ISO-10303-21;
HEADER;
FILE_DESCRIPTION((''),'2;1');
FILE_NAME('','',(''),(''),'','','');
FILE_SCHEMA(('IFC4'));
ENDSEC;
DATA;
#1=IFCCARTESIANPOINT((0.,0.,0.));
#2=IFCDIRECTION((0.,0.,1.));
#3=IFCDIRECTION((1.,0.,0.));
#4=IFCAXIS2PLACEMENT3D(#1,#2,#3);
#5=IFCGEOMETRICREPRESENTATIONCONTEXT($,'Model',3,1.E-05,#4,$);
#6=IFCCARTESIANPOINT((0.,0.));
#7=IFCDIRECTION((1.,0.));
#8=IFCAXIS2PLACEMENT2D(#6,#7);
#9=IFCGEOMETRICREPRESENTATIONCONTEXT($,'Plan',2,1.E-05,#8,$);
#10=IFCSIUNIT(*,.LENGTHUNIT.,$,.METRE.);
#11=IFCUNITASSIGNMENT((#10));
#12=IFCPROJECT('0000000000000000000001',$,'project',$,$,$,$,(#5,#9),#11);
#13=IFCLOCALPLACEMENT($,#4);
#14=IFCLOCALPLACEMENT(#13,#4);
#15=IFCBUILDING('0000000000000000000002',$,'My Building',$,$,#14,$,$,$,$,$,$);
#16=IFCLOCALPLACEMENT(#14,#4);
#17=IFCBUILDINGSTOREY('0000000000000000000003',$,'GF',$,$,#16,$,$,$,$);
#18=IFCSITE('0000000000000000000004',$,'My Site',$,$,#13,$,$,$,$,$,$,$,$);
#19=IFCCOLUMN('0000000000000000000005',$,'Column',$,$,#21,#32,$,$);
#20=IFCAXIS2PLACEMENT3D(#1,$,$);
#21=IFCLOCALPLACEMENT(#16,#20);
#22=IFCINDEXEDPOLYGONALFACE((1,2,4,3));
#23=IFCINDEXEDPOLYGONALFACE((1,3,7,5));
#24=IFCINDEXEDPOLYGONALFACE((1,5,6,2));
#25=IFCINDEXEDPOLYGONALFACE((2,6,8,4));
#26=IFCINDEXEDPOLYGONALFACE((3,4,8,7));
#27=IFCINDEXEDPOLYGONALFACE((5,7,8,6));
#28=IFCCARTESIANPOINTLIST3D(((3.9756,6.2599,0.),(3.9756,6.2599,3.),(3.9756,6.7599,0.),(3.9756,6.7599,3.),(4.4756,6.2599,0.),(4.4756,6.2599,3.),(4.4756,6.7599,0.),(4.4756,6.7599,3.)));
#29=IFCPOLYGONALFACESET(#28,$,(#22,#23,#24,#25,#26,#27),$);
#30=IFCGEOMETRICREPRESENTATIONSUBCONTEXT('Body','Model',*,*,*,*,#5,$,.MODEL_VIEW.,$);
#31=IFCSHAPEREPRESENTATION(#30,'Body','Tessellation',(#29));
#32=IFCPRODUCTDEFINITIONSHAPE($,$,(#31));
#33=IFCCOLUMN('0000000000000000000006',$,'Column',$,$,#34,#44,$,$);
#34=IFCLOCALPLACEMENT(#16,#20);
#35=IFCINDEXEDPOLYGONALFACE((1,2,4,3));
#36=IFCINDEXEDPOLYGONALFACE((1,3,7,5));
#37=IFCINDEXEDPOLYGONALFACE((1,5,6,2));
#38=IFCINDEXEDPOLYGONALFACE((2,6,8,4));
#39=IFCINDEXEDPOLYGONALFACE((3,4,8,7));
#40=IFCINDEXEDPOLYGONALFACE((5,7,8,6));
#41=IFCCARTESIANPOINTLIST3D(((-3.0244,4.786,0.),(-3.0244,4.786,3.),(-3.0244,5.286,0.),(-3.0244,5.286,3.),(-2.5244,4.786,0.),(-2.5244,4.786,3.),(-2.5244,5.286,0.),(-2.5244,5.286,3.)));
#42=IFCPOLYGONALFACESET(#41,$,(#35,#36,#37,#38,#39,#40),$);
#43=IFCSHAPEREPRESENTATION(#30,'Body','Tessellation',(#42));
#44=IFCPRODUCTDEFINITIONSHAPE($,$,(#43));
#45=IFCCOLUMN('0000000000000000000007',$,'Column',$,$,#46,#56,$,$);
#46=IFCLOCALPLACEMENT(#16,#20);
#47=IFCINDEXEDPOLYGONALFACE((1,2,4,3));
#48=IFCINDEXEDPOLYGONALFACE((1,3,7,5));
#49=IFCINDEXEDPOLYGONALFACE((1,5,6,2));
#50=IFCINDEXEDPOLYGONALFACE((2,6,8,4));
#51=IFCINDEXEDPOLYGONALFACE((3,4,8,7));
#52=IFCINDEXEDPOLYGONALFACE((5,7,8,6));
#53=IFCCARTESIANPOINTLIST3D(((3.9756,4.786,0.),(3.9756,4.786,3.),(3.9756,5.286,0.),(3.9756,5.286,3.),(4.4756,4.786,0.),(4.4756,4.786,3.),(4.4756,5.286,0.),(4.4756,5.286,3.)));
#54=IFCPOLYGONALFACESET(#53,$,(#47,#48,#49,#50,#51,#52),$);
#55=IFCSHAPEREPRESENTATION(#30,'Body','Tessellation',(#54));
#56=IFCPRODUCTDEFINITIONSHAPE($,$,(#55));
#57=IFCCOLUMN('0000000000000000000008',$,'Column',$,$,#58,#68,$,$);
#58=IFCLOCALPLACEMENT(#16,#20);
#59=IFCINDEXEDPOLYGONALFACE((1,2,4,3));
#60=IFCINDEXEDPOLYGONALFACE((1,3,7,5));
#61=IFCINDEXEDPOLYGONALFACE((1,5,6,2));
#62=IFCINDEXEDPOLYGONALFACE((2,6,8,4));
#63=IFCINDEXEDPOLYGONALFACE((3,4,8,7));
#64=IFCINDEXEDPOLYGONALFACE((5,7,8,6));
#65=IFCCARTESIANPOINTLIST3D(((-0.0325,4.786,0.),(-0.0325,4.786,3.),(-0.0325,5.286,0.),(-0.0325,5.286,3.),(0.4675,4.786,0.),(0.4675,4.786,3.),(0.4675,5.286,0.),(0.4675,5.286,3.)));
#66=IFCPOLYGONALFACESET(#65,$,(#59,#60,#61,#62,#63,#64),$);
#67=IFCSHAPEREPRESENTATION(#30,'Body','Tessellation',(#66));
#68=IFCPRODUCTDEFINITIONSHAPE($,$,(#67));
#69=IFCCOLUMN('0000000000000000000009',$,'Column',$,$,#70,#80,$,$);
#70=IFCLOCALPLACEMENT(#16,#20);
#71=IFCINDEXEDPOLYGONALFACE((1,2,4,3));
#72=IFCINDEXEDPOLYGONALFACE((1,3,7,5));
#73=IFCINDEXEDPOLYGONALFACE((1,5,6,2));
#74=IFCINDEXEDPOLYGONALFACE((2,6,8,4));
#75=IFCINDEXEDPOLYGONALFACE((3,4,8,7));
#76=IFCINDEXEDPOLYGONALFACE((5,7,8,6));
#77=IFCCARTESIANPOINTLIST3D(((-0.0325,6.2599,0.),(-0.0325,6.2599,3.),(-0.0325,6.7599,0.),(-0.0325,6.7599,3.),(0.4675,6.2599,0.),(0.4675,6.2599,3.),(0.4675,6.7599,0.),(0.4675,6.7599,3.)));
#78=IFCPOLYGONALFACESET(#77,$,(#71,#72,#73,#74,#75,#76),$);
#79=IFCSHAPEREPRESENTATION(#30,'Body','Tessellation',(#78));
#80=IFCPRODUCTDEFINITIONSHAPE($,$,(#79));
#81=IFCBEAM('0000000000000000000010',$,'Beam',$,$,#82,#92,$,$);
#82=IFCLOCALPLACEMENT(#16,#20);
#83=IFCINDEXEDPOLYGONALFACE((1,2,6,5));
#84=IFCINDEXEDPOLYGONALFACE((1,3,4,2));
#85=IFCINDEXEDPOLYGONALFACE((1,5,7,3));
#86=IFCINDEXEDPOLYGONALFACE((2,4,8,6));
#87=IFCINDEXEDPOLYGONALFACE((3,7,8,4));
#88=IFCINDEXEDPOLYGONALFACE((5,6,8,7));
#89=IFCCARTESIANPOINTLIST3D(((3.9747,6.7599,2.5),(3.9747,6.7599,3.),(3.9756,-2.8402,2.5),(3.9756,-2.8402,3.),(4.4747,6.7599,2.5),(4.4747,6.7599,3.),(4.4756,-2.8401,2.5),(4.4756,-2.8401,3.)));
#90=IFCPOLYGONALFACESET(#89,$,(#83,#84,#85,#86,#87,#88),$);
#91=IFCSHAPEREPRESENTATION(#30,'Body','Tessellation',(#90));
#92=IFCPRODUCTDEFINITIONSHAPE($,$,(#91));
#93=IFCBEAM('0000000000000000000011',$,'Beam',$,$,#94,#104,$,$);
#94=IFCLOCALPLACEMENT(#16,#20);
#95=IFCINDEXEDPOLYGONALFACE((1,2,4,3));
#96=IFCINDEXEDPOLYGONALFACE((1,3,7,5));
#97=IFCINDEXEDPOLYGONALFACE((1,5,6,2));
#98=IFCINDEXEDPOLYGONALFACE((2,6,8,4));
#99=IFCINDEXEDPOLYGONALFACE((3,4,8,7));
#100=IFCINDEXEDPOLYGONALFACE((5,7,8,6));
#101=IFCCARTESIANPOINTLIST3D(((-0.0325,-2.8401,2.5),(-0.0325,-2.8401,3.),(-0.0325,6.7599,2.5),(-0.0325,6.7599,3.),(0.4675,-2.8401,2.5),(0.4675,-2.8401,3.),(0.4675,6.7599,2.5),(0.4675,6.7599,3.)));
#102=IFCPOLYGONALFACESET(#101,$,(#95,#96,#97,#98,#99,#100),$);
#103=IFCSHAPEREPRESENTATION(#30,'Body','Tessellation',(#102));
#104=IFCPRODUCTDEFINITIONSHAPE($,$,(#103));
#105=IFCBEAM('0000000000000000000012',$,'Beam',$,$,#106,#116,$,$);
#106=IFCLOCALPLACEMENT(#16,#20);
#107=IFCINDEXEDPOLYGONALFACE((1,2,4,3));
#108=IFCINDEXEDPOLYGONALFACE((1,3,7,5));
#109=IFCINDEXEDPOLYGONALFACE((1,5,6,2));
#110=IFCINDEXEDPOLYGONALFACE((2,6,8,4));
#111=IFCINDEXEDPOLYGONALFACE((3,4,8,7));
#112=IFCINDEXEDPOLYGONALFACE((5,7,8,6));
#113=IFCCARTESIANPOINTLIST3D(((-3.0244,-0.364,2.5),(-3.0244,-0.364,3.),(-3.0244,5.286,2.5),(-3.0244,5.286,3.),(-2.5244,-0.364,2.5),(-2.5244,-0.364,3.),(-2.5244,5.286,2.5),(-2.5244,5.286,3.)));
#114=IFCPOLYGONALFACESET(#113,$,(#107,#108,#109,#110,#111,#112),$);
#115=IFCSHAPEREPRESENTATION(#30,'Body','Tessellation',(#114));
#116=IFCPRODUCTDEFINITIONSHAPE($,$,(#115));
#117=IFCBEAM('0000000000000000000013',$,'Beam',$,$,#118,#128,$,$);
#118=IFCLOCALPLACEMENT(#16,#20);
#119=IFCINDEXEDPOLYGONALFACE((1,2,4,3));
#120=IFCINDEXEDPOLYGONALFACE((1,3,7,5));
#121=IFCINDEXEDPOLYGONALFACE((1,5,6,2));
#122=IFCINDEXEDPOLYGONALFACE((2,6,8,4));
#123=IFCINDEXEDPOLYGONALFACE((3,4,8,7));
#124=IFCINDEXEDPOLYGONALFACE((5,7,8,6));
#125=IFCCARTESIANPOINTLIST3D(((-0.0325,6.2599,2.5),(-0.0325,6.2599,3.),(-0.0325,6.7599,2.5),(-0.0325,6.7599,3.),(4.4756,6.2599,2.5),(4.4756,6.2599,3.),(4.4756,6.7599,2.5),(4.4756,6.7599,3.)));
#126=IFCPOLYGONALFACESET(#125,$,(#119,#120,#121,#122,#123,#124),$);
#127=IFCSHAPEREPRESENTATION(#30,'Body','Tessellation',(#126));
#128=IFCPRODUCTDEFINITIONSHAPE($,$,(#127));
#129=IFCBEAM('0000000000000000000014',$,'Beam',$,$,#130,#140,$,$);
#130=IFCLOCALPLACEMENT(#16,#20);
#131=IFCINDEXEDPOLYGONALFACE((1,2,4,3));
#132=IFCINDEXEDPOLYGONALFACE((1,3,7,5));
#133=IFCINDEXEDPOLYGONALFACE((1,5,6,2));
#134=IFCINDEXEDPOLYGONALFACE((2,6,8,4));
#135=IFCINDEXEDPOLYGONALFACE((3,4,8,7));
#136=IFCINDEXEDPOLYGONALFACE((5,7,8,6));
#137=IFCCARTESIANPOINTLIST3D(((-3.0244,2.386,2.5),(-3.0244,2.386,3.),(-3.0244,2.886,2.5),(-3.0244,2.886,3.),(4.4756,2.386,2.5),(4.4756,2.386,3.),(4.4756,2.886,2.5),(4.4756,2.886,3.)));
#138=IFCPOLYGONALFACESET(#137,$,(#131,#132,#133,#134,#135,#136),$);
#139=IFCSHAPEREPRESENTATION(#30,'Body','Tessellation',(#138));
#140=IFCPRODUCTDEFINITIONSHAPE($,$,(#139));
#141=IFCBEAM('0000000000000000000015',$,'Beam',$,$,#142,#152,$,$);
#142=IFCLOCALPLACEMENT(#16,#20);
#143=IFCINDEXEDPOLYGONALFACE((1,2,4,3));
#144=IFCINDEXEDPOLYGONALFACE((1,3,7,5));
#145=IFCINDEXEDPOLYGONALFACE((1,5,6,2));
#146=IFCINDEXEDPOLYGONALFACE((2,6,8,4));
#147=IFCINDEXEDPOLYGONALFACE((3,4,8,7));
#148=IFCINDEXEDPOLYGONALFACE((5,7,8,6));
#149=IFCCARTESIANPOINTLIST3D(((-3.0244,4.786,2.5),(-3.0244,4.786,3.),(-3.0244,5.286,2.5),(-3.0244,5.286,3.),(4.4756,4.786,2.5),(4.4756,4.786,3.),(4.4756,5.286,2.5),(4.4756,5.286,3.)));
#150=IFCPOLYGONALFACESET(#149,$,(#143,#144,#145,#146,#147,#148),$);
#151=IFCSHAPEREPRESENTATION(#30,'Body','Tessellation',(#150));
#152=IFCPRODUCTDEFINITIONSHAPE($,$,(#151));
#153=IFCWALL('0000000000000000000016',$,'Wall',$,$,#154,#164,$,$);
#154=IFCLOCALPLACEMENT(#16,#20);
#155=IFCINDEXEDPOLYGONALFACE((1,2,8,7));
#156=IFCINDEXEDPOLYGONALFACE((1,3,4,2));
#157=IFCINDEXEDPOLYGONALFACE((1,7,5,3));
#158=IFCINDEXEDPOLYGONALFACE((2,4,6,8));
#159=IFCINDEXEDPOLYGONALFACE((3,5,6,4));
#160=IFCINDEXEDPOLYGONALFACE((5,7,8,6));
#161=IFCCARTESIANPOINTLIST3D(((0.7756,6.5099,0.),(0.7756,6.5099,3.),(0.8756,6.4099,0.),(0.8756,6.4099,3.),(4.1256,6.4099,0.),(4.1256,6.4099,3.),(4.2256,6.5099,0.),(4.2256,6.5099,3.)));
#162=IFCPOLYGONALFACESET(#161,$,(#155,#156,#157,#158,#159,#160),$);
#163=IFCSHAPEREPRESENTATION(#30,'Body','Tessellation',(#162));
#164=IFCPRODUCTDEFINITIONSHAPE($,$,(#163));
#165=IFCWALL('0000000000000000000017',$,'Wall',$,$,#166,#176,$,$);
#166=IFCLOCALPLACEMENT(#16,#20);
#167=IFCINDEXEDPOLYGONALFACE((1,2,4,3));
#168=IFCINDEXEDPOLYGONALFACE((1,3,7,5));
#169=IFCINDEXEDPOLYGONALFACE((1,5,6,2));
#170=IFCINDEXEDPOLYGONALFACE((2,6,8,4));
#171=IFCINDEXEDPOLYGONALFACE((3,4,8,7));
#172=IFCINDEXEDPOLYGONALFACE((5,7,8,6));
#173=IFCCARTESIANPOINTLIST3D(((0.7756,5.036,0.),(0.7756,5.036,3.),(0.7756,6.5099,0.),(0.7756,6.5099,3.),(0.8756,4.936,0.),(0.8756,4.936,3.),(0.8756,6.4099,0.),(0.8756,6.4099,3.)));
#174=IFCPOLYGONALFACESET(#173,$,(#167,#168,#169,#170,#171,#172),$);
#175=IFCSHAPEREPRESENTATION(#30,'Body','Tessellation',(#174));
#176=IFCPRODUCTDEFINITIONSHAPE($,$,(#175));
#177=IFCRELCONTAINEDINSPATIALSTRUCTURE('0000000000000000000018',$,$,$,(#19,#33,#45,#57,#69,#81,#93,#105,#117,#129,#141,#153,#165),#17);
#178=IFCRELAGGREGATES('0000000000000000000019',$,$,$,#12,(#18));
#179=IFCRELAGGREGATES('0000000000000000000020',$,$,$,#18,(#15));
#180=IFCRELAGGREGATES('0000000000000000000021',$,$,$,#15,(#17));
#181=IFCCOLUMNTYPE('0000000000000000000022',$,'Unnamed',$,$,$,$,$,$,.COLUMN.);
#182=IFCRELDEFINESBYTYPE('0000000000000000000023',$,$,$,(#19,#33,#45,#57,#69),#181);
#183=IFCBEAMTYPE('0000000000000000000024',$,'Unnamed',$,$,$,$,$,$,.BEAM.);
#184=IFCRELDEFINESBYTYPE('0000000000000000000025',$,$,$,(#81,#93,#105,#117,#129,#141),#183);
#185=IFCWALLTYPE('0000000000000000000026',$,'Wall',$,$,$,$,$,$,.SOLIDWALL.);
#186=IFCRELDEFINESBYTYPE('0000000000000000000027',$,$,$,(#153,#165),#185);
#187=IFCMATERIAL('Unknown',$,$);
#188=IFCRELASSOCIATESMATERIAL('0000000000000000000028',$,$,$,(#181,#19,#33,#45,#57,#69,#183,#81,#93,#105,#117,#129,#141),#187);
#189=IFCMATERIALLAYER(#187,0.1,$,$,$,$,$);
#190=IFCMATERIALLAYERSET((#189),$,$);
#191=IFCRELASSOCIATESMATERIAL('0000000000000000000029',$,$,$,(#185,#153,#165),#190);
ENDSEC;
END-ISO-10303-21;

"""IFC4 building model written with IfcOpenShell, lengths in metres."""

from ifc_helpers import new_model, si_unit, frame, origin_with_axes, origin_2d_with_axis, place, context, subcontext, project, spatial, line, indexed_curve, rectangle, outline, extrude, material, layer, layer_set, layer_usage, material_profile, profile_set, profile_usage, type_object, element, save


model = new_model("IFC4")

# Units and contexts
model_context = context("Model", 3, precision=1e-05, world=origin_with_axes())
plan_context = context("Plan", 2, precision=1e-05, world=origin_2d_with_axis())
body_context_1 = subcontext(model_context, "Body", "Model", "MODEL_VIEW")
ifc_project = project(units=[si_unit("LENGTHUNIT", "METRE")], contexts=[model_context, plan_context])

# Site, building, storey
site_placement = place(None, origin_with_axes())
site = spatial("IfcSite", under=ifc_project, at=site_placement, Name="My Site")
building_placement = place(site_placement, origin_with_axes())
building = spatial("IfcBuilding", under=site, at=building_placement, Name="My Building")
storey_placement = place(building_placement, origin_with_axes())
storey = spatial("IfcBuildingStorey", under=building, at=storey_placement, Name="GF")

# Columns
ifc_material_1 = material(Name="Unknown")
ifc_material_profile_1 = material_profile(ifc_material_1, rectangle(XDim=0.5, YDim=0.5))
ifc_profile_set_1 = profile_set([ifc_material_profile_1])
ifc_profile_usage_1 = profile_usage(ifc_profile_set_1, cardinal=5)
column_type = type_object("IfcColumnType", Name="Unnamed", PredefinedType="COLUMN", material=ifc_profile_set_1)
column_1_placement = place(storey_placement, frame((4.2256, 6.5099, 0.0), z_axis=(0.0, 0.0, 1.0), x_axis=(1.0, 0.0, 0.0)))
element("IfcColumn", 1, at=column_1_placement, inside=storey, type_object=column_type, material=ifc_profile_usage_1, Name="Column", context=body_context_1, shape_type="SweptSolid", body=[
    extrude(rectangle(XDim=0.5, YDim=0.5), origin_with_axes(), (0.0, 0.0, 1.0), 3.0),
])
ifc_profile_usage_2 = profile_usage(ifc_profile_set_1, cardinal=5)
column_2_placement = place(storey_placement, frame((-2.7744, 5.036, 0.0), z_axis=(0.0, 0.0, 1.0), x_axis=(1.0, 0.0, 0.0)))
element("IfcColumn", 2, at=column_2_placement, inside=storey, type_object=column_type, material=ifc_profile_usage_2, Name="Column", context=body_context_1, shape_type="SweptSolid", body=[
    extrude(rectangle(XDim=0.5, YDim=0.5), origin_with_axes(), (0.0, 0.0, 1.0), 3.0),
])
ifc_profile_usage_3 = profile_usage(ifc_profile_set_1, cardinal=5)
column_3_placement = place(storey_placement, frame((4.2256, 5.036, 0.0), z_axis=(0.0, 0.0, 1.0), x_axis=(1.0, 0.0, 0.0)))
element("IfcColumn", 3, at=column_3_placement, inside=storey, type_object=column_type, material=ifc_profile_usage_3, Name="Column", context=body_context_1, shape_type="SweptSolid", body=[
    extrude(rectangle(XDim=0.5, YDim=0.5), origin_with_axes(), (0.0, 0.0, 1.0), 3.0),
])
ifc_profile_usage_4 = profile_usage(ifc_profile_set_1, cardinal=5)
column_4_placement = place(storey_placement, frame((0.2175, 5.036, 0.0), z_axis=(0.0, 0.0, 1.0), x_axis=(1.0, 0.0, 0.0)))
element("IfcColumn", 4, at=column_4_placement, inside=storey, type_object=column_type, material=ifc_profile_usage_4, Name="Column", context=body_context_1, shape_type="SweptSolid", body=[
    extrude(rectangle(XDim=0.5, YDim=0.5), origin_with_axes(), (0.0, 0.0, 1.0), 3.0),
])
ifc_profile_usage_5 = profile_usage(ifc_profile_set_1, cardinal=5)
column_5_placement = place(storey_placement, frame((0.2175, 6.5099, 0.0), z_axis=(0.0, 0.0, 1.0), x_axis=(1.0, 0.0, 0.0)))
element("IfcColumn", 5, at=column_5_placement, inside=storey, type_object=column_type, material=ifc_profile_usage_5, Name="Column", context=body_context_1, shape_type="SweptSolid", body=[
    extrude(rectangle(XDim=0.5, YDim=0.5), origin_with_axes(), (0.0, 0.0, 1.0), 3.0),
])

# Beams
ifc_material_profile_2 = material_profile(ifc_material_1, rectangle(XDim=0.5, YDim=0.5))
ifc_profile_set_2 = profile_set([ifc_material_profile_2])
ifc_profile_usage_6 = profile_usage(ifc_profile_set_2, cardinal=7)
beam_type = type_object("IfcBeamType", Name="Unnamed", PredefinedType="BEAM", material=ifc_profile_set_2)
beam_1_placement = place(storey_placement, frame((4.4747, 6.7599, 3.0), z_axis=(0.000095, -1.0, 0.0), x_axis=(1.0, 0.000095, 0.0)))
element("IfcBeam", 6, at=beam_1_placement, inside=storey, type_object=beam_type, material=ifc_profile_usage_6, Name="Beam", context=body_context_1, shape_type="SweptSolid", body=[
    extrude(rectangle(XDim=0.5, YDim=0.5), frame((-0.25, -0.25, 0.0), z_axis=(0.0, 0.0, 1.0), x_axis=(1.0, 0.0, 0.0)), (0.0, 0.0, 1.0), 9.6),
])
ifc_profile_usage_7 = profile_usage(ifc_profile_set_2, cardinal=7)
beam_2_placement = place(storey_placement, frame((0.4675, 6.7599, 3.0), z_axis=(0.0, -1.0, 0.0), x_axis=(1.0, 0.0, 0.0)))
element("IfcBeam", 7, at=beam_2_placement, inside=storey, type_object=beam_type, material=ifc_profile_usage_7, Name="Beam", context=body_context_1, shape_type="SweptSolid", body=[
    extrude(rectangle(XDim=0.5, YDim=0.5), frame((-0.25, -0.25, 0.0), z_axis=(0.0, 0.0, 1.0), x_axis=(1.0, 0.0, 0.0)), (0.0, 0.0, 1.0), 9.6),
])
ifc_profile_usage_8 = profile_usage(ifc_profile_set_2, cardinal=7)
beam_3_placement = place(storey_placement, frame((-2.5244, 5.286, 3.0), z_axis=(0.0, -1.0, 0.0), x_axis=(1.0, 0.0, 0.0)))
element("IfcBeam", 8, at=beam_3_placement, inside=storey, type_object=beam_type, material=ifc_profile_usage_8, Name="Beam", context=body_context_1, shape_type="SweptSolid", body=[
    extrude(rectangle(XDim=0.5, YDim=0.5), frame((-0.25, -0.25, 0.0), z_axis=(0.0, 0.0, 1.0), x_axis=(1.0, 0.0, 0.0)), (0.0, 0.0, 1.0), 5.65),
])
ifc_profile_usage_9 = profile_usage(ifc_profile_set_2, cardinal=7)
beam_4_placement = place(storey_placement, frame((-0.0325, 6.7599, 3.0), z_axis=(1.0, 0.0, 0.0), x_axis=(0.0, 1.0, 0.0)))
element("IfcBeam", 9, at=beam_4_placement, inside=storey, type_object=beam_type, material=ifc_profile_usage_9, Name="Beam", context=body_context_1, shape_type="SweptSolid", body=[
    extrude(rectangle(XDim=0.5, YDim=0.5), frame((-0.25, -0.25, 0.0), z_axis=(0.0, 0.0, 1.0), x_axis=(1.0, 0.0, 0.0)), (0.0, 0.0, 1.0), 4.5081),
])
ifc_profile_usage_10 = profile_usage(ifc_profile_set_2, cardinal=7)
beam_5_placement = place(storey_placement, frame((-3.0244, 2.886, 3.0), z_axis=(1.0, 0.0, 0.0), x_axis=(0.0, 1.0, 0.0)))
element("IfcBeam", 10, at=beam_5_placement, inside=storey, type_object=beam_type, material=ifc_profile_usage_10, Name="Beam", context=body_context_1, shape_type="SweptSolid", body=[
    extrude(rectangle(XDim=0.5, YDim=0.5), frame((-0.25, -0.25, 0.0), z_axis=(0.0, 0.0, 1.0), x_axis=(1.0, 0.0, 0.0)), (0.0, 0.0, 1.0), 7.5001),
])
ifc_profile_usage_11 = profile_usage(ifc_profile_set_2, cardinal=7)
beam_6_placement = place(storey_placement, frame((-3.0244, 5.286, 3.0), z_axis=(1.0, 0.0, 0.0), x_axis=(0.0, 1.0, 0.0)))
element("IfcBeam", 11, at=beam_6_placement, inside=storey, type_object=beam_type, material=ifc_profile_usage_11, Name="Beam", context=body_context_1, shape_type="SweptSolid", body=[
    extrude(rectangle(XDim=0.5, YDim=0.5), frame((-0.25, -0.25, 0.0), z_axis=(0.0, 0.0, 1.0), x_axis=(1.0, 0.0, 0.0)), (0.0, 0.0, 1.0), 7.5),
])

# Walls
ifc_layer_1 = layer(ifc_material_1, 0.1)
ifc_layer_set_1 = layer_set([ifc_layer_1])
ifc_layer_usage_1 = layer_usage(ifc_layer_set_1, "AXIS2", "POSITIVE", 0.0)
wall_type = type_object("IfcWallType", Name="Wall", PredefinedType="SOLIDWALL", material=ifc_layer_set_1)
wall_1_placement = place(storey_placement, frame((4.2256, 6.5099, 0.0), z_axis=(0.0, 0.0, 1.0), x_axis=(-1.0, 0.0, 0.0)))
element("IfcWall", 12, at=wall_1_placement, inside=storey, type_object=wall_type, material=ifc_layer_usage_1, Name="Wall", context=body_context_1, shape_type="SweptSolid", body=[
    extrude(outline(indexed_curve([(0.0, 0.0), (0.1, 0.1), (3.35, 0.1), (3.45, 0.0)], segments=[line(1, 2, 3, 4, 1)])), origin_with_axes(), (0.0, 0.0, 1.0), 3.0),
])
ifc_layer_usage_2 = layer_usage(ifc_layer_set_1, "AXIS2", "POSITIVE", 0.0)
wall_2_placement = place(storey_placement, frame((0.7756, 6.5099, 0.0), z_axis=(0.0, 0.0, 1.0), x_axis=(0.0, -1.0, 0.0)))
element("IfcWall", 13, at=wall_2_placement, inside=storey, type_object=wall_type, material=ifc_layer_usage_2, Name="Wall", context=body_context_1, shape_type="SweptSolid", body=[
    extrude(outline(indexed_curve([(0.0, 0.0), (0.1, 0.1), (1.5739, 0.1), (1.4739, 0.0)], segments=[line(1, 2, 3, 4, 1)])), origin_with_axes(), (0.0, 0.0, 1.0), 3.0),
])

save(model, "model.ifc")
